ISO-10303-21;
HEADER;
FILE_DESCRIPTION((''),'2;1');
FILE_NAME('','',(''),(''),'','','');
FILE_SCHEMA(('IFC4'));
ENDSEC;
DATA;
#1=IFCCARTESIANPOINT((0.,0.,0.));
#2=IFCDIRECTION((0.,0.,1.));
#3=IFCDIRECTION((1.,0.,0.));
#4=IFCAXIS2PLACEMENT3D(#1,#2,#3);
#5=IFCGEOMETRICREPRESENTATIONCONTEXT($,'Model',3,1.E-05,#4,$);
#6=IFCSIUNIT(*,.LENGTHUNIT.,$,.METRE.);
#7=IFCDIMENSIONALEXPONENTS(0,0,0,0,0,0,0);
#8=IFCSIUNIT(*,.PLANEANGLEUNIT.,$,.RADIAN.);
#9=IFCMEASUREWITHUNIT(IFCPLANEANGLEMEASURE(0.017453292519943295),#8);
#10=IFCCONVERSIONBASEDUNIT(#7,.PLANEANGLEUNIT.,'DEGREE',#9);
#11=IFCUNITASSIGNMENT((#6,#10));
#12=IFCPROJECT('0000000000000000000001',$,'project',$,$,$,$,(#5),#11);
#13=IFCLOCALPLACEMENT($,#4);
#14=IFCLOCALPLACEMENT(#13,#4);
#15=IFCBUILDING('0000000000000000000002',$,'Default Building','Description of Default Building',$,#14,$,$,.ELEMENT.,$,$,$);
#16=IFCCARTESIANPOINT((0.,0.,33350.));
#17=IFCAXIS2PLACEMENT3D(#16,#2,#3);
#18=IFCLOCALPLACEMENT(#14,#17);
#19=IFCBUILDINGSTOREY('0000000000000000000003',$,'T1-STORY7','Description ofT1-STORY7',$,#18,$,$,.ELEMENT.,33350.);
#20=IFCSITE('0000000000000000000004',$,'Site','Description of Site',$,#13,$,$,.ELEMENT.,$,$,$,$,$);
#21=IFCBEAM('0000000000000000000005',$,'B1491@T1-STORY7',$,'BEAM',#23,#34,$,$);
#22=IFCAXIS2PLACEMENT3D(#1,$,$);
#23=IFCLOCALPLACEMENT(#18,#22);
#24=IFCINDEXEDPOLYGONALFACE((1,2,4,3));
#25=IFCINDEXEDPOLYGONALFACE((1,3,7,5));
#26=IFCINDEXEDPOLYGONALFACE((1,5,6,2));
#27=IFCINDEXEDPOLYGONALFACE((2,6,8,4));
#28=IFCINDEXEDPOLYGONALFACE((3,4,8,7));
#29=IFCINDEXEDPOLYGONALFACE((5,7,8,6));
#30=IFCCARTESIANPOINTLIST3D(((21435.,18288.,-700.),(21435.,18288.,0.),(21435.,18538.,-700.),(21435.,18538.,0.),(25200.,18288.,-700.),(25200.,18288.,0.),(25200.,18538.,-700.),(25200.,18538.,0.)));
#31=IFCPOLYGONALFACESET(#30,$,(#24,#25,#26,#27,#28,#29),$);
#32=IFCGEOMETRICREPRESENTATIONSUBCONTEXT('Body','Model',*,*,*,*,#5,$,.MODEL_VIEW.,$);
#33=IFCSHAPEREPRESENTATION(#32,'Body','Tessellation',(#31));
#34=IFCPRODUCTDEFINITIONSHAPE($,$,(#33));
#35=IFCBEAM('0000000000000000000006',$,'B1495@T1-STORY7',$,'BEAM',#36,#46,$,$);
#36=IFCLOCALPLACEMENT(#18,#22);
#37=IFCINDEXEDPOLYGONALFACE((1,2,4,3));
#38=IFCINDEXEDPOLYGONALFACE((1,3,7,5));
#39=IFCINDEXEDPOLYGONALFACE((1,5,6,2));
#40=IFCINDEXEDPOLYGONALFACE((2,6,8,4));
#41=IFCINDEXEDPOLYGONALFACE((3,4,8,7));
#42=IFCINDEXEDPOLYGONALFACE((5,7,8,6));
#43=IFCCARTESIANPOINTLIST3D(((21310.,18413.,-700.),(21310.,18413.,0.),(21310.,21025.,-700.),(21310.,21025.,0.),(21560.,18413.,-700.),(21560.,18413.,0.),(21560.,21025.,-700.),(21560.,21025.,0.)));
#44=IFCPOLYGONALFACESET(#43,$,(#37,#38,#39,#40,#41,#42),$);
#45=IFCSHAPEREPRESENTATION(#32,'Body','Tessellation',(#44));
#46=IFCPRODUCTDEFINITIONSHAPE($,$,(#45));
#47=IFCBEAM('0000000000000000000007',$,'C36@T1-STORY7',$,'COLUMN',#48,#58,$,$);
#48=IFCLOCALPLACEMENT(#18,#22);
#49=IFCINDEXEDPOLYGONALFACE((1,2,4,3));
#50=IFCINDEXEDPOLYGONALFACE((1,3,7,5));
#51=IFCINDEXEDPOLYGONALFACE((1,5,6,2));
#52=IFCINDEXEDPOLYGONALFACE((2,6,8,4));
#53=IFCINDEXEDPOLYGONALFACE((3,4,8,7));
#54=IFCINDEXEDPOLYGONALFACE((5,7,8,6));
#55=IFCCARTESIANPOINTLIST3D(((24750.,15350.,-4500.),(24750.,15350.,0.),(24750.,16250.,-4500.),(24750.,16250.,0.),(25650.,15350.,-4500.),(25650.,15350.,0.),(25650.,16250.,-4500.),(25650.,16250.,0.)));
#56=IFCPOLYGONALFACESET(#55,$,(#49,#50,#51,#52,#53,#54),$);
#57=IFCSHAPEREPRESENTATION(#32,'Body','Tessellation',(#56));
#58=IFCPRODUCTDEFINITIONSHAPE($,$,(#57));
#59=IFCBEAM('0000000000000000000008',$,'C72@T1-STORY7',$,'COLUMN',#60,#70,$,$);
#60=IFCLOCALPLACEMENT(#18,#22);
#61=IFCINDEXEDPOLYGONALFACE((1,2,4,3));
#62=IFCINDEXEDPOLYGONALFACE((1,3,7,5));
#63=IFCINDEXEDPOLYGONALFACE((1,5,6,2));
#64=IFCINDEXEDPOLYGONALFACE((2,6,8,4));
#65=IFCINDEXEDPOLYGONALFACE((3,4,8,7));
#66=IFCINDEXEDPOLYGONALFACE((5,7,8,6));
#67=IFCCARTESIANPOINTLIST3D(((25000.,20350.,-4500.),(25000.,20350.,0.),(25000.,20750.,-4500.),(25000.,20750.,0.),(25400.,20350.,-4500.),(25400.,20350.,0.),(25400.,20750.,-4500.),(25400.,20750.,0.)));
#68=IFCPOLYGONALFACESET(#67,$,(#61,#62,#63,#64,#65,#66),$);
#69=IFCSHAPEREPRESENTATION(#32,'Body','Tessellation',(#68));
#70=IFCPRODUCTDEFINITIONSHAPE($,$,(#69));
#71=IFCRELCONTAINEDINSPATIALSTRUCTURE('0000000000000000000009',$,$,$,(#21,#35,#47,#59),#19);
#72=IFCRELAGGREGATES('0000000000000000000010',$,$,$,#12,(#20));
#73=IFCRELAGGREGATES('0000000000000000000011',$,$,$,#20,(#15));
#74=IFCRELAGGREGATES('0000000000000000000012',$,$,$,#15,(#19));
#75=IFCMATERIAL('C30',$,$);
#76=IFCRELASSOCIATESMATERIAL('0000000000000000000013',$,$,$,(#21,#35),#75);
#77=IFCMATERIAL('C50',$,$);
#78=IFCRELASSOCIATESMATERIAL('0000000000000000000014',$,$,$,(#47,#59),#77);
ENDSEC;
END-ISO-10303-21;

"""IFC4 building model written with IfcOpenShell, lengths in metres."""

from ifc_helpers import new_model, entity, si_unit, converted_unit, frame, origin_with_axes, place, context, subcontext, project, spatial, rectangle, extrude, material, element, save


model = new_model("IFC4")

# Units and contexts
model_context = context("Model", 3, precision=1e-05, world=origin_with_axes())
body_context = subcontext(model_context, "Body", "Model", "MODEL_VIEW")
ifc_project = project(units=[si_unit("LENGTHUNIT", "METRE"), converted_unit("PLANEANGLEUNIT", "DEGREE", entity("IfcPlaneAngleMeasure", 0.017453292519943295), si_unit("PLANEANGLEUNIT", "RADIAN"), dimensions=[0, 0, 0, 0, 0, 0, 0])], contexts=[model_context])

# Site, building, storey
site_placement = place(None, origin_with_axes())
site = spatial("IfcSite", under=ifc_project, at=site_placement, Name="Site", Description="Description of Site", CompositionType="ELEMENT")
building_placement = place(site_placement, origin_with_axes())
building = spatial("IfcBuilding", under=site, at=building_placement, Name="Default Building", Description="Description of Default Building", CompositionType="ELEMENT")
storey_placement = place(building_placement, frame((0.0, 0.0, 33350.0), z_axis=(0.0, 0.0, 1.0), x_axis=(1.0, 0.0, 0.0)))
storey = spatial("IfcBuildingStorey", under=building, at=storey_placement, Name="T1-STORY7", Description="Description ofT1-STORY7", CompositionType="ELEMENT", Elevation=33350.0)

# Beams
ifc_material_1 = material(Name="C30")
beam_1_placement = place(storey_placement, frame((21435.0, 18413.0, -350.0), z_axis=(1.0, 0.0, 0.0), x_axis=(0.0, 1.0, 0.0)))
element("IfcBeam", 1, at=beam_1_placement, inside=storey, material=ifc_material_1, Name="B1491@T1-STORY7", ObjectType="BEAM", context=body_context, shape_type="SweptSolid", body=[
    extrude(rectangle(XDim=250.0, YDim=700.0), origin_with_axes(), (0.0, 0.0, 1.0), 3765.0),
])
beam_2_placement = place(storey_placement, frame((21435.0, 18413.0, -350.0), z_axis=(0.0, 1.0, 0.0), x_axis=(-1.0, 0.0, 0.0)))
element("IfcBeam", 2, at=beam_2_placement, inside=storey, material=ifc_material_1, Name="B1495@T1-STORY7", ObjectType="BEAM", context=body_context, shape_type="SweptSolid", body=[
    extrude(rectangle(XDim=250.0, YDim=700.0), origin_with_axes(), (0.0, 0.0, 1.0), 2612.0),
])
ifc_material_2 = material(Name="C50")
beam_3_placement = place(storey_placement, frame((25200.0, 15800.0, -4500.0), z_axis=(0.0, 0.0, 1.0), x_axis=(-1.0, 0.0, 0.0)))
element("IfcBeam", 3, at=beam_3_placement, inside=storey, material=ifc_material_2, Name="C36@T1-STORY7", ObjectType="COLUMN", context=body_context, shape_type="SweptSolid", body=[
    extrude(rectangle(XDim=900.0, YDim=900.0), origin_with_axes(), (0.0, 0.0, 1.0), 4500.0),
])
beam_4_placement = place(storey_placement, frame((25200.0, 20550.0, -4500.0), z_axis=(0.0, 0.0, 1.0), x_axis=(-1.0, 0.0, 0.0)))
element("IfcBeam", 4, at=beam_4_placement, inside=storey, material=ifc_material_2, Name="C72@T1-STORY7", ObjectType="COLUMN", context=body_context, shape_type="SweptSolid", body=[
    extrude(rectangle(XDim=400.0, YDim=400.0), origin_with_axes(), (0.0, 0.0, 1.0), 4500.0),
])

save(model, "model.ifc")
